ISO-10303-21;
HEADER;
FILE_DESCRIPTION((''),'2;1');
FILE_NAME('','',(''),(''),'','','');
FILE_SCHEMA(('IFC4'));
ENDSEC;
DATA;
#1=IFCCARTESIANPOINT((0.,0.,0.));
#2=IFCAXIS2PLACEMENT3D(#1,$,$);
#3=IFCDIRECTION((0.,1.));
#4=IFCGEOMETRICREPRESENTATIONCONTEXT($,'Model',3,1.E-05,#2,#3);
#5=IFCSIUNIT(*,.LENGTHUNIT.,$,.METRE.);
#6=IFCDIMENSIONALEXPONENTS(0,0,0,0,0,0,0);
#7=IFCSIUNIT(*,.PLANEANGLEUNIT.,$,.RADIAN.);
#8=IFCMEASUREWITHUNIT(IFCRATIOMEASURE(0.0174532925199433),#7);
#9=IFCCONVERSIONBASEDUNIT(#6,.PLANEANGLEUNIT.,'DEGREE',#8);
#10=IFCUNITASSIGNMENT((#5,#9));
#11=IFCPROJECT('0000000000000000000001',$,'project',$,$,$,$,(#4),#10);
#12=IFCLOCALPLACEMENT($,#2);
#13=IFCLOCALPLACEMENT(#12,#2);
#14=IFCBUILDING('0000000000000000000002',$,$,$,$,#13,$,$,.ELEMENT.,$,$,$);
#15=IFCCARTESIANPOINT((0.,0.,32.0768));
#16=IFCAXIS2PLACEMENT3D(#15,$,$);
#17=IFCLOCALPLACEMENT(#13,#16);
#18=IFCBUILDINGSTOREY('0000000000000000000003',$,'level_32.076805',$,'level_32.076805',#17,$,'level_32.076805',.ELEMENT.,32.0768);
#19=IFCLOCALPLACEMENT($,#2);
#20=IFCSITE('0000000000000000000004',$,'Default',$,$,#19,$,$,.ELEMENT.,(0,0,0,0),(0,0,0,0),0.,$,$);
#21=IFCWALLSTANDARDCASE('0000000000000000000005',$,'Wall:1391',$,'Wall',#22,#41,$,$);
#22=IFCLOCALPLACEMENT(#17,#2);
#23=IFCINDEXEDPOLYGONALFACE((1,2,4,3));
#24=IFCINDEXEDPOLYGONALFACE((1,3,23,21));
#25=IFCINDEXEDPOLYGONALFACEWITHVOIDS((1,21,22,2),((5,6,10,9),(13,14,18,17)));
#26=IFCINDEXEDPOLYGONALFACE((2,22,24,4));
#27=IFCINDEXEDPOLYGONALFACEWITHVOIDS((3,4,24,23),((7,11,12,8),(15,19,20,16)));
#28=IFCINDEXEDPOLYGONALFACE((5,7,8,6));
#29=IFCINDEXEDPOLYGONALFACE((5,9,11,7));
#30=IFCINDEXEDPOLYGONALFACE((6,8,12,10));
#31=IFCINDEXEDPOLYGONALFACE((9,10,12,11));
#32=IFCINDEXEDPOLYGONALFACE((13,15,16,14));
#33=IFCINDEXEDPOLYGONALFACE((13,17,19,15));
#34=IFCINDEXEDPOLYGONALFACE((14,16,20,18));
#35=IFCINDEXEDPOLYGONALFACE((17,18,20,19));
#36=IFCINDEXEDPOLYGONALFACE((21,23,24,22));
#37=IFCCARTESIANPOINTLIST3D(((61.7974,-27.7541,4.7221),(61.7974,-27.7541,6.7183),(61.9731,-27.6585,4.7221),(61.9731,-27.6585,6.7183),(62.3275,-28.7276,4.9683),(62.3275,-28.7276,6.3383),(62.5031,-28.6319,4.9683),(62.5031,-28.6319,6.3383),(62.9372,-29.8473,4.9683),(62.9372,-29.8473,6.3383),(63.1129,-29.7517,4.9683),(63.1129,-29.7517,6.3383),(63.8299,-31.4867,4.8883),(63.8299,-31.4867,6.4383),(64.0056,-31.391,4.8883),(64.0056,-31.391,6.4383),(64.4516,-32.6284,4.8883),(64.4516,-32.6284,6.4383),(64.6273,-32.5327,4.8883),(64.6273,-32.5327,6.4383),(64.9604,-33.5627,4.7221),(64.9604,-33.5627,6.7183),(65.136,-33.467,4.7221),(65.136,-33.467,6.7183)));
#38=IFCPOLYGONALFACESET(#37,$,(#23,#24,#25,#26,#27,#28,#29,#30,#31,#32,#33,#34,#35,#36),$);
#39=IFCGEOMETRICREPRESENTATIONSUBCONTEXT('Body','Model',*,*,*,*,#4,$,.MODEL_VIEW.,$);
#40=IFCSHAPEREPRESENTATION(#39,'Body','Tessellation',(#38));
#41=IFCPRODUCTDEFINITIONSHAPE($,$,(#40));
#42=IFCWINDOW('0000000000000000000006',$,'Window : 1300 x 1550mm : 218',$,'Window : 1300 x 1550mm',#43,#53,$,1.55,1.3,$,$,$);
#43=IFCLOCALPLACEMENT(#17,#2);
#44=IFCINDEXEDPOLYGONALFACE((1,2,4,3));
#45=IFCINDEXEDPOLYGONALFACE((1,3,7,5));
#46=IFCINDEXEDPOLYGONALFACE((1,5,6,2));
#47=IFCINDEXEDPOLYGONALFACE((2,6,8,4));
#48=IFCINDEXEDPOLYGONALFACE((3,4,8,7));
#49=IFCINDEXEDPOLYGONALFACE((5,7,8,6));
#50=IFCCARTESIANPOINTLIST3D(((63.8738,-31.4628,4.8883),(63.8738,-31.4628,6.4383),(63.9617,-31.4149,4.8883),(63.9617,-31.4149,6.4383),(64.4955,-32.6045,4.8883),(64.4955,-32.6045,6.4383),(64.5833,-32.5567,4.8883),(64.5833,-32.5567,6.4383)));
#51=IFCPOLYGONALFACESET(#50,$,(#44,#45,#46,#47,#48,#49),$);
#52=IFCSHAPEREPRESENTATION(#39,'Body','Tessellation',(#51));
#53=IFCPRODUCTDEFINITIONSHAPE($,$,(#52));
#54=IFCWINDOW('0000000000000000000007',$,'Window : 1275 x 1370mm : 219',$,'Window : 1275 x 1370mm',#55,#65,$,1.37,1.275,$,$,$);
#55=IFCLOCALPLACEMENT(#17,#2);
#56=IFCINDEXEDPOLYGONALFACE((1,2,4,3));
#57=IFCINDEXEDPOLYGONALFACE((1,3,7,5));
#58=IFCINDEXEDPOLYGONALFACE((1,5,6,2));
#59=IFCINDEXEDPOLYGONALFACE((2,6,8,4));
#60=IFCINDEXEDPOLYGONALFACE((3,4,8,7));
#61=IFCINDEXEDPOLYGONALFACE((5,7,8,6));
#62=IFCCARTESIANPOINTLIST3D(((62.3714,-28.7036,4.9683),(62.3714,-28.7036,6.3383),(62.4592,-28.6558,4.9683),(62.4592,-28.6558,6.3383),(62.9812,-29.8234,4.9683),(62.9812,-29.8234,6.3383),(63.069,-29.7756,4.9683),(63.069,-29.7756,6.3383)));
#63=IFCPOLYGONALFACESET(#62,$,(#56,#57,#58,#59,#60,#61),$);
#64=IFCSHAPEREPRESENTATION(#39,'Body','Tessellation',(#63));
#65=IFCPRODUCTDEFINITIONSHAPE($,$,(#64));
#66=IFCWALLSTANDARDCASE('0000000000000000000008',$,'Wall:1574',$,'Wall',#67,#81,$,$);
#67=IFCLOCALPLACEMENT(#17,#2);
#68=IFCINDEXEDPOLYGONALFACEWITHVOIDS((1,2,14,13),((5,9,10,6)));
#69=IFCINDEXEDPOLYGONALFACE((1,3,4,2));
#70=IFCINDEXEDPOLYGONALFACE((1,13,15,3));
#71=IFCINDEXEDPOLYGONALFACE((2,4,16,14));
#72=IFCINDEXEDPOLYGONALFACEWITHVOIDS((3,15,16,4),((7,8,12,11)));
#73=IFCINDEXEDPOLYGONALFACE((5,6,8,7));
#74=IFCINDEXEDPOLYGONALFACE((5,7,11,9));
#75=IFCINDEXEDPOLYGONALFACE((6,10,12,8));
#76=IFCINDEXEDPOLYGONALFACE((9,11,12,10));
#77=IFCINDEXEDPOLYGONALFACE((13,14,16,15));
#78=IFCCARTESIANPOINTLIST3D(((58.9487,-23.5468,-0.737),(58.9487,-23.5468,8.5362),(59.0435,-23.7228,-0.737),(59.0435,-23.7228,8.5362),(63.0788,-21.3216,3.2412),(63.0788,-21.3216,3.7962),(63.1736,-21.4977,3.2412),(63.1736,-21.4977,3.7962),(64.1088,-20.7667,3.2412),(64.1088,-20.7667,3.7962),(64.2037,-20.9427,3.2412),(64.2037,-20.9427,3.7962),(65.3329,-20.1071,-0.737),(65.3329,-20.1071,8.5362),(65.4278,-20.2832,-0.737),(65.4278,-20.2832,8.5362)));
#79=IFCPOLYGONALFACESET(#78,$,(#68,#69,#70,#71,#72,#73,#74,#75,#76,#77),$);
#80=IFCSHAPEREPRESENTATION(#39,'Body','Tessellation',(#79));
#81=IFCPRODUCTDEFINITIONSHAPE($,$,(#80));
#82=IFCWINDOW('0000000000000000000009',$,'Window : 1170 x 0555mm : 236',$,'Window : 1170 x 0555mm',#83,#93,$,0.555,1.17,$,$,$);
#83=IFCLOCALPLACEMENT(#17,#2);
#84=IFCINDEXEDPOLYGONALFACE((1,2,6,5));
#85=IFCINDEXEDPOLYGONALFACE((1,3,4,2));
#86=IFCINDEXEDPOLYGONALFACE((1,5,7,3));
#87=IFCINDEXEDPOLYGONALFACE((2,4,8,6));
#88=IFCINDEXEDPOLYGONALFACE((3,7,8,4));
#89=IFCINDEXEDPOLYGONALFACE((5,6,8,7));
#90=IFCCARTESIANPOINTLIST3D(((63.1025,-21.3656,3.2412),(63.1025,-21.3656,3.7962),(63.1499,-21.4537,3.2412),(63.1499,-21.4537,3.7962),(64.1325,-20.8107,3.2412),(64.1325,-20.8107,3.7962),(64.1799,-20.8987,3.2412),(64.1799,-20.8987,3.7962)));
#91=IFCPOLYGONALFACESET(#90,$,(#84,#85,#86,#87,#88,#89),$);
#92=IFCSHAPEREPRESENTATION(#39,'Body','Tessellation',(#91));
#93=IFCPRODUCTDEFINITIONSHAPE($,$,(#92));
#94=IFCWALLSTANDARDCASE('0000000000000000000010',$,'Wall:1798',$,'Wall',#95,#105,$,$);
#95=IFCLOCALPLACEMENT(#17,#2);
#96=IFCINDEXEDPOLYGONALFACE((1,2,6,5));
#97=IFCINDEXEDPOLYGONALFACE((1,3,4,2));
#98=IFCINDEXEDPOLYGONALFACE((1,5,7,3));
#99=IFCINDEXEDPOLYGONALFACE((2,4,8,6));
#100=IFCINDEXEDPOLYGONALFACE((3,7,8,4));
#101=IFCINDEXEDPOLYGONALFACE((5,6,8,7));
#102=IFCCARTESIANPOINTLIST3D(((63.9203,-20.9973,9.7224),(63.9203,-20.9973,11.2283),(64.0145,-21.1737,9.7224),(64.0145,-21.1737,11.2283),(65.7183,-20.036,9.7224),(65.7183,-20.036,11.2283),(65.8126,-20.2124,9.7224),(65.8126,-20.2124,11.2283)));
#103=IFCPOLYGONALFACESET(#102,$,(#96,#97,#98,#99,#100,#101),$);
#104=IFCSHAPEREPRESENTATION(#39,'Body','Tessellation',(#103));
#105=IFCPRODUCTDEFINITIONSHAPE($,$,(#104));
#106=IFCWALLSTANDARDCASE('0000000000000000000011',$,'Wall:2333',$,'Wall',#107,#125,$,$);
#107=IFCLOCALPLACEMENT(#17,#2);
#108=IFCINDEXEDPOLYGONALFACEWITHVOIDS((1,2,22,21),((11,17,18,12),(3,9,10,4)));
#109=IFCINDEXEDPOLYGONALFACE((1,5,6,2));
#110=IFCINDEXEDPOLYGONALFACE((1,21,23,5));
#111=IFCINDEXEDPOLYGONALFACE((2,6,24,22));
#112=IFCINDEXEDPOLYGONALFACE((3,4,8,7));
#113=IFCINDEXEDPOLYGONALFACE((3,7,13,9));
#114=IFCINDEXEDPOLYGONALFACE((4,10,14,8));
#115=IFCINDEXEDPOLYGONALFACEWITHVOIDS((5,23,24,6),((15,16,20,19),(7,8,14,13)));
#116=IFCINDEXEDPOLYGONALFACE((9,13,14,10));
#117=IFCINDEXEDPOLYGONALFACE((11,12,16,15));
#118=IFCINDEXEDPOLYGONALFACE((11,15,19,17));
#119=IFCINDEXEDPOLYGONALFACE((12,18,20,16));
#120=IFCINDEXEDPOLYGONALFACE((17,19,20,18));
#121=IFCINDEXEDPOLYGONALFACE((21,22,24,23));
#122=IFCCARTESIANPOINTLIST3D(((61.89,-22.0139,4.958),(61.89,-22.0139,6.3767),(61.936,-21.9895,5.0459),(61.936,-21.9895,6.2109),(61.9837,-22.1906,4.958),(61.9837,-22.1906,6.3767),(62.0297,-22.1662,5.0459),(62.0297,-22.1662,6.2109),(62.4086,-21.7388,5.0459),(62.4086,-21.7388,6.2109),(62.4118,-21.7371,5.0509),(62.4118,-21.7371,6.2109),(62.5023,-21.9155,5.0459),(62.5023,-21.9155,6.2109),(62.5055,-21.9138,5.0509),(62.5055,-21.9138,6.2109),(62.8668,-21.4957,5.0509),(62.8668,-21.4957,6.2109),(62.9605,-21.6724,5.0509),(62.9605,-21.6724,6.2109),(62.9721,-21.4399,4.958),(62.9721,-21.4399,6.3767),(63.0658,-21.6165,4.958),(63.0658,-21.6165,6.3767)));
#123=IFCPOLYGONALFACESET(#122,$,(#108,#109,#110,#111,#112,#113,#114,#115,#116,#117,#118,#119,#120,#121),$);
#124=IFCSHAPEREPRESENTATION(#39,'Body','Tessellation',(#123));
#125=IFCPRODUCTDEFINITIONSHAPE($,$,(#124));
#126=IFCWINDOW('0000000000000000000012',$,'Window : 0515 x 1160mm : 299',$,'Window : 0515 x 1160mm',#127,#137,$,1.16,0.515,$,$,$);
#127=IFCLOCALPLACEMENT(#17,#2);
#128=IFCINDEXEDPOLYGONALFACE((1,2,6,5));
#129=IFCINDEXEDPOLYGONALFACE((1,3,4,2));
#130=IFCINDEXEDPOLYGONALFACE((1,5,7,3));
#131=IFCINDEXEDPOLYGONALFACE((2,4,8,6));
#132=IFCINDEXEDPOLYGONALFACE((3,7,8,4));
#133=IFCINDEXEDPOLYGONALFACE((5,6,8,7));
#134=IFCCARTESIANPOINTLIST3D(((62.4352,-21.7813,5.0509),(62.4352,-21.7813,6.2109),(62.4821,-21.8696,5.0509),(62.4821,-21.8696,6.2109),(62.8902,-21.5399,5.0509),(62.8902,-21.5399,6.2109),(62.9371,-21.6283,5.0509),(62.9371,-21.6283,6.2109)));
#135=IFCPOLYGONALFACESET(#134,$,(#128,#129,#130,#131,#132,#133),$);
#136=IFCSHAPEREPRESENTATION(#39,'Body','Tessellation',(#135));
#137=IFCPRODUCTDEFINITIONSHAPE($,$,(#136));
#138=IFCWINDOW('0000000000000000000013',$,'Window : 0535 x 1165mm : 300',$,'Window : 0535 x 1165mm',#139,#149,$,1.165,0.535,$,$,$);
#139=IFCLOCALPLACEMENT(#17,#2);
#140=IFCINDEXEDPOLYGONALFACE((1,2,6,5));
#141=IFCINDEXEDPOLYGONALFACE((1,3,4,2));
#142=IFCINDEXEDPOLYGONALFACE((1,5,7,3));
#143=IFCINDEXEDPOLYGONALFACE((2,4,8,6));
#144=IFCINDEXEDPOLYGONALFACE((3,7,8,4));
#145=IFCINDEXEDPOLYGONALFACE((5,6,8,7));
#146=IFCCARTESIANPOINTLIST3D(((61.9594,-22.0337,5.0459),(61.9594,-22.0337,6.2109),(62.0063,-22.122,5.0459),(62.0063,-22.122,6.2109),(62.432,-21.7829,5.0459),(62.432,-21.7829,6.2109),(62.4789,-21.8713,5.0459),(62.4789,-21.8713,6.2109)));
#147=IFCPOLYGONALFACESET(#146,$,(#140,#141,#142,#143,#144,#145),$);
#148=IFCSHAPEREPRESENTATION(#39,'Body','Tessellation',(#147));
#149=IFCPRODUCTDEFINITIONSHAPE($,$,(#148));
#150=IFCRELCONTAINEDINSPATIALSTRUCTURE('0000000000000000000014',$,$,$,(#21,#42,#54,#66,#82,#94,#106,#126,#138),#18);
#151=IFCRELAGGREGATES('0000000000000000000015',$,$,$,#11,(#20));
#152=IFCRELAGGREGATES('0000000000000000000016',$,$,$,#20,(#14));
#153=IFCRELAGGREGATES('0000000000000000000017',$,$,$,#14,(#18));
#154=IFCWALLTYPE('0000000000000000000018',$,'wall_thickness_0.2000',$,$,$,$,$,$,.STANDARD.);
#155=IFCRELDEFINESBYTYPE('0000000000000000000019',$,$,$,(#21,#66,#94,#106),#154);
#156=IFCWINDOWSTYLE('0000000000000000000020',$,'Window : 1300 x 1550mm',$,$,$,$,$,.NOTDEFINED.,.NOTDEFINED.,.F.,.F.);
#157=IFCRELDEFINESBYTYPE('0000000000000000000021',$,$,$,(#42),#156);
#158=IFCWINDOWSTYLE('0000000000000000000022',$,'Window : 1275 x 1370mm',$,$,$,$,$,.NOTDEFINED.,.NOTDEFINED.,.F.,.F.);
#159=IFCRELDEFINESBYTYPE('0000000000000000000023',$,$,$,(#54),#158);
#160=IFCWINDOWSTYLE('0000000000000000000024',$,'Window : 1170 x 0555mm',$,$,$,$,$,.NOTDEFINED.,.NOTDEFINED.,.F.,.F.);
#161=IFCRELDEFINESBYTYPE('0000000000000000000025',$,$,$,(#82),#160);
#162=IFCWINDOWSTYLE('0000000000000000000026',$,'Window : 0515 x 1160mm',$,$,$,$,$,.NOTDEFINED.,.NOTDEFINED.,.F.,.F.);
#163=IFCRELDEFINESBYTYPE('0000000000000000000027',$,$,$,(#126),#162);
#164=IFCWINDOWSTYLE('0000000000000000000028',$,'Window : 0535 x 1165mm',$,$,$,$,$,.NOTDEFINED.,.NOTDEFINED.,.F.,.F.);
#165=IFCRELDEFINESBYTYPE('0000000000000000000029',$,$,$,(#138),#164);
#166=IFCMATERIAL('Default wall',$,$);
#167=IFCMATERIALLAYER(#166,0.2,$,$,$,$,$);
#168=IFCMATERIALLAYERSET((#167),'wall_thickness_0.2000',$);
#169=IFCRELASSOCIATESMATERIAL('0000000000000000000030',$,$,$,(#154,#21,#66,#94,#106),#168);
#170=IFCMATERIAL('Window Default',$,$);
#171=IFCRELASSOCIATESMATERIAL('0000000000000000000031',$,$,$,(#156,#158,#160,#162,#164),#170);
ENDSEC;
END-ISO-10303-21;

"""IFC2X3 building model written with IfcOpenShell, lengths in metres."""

from ifc_helpers import new_model, entity, si_unit, converted_unit, direction, frame, frame_2d, origin, origin_2d_with_axis, place, context, subcontext, project, spatial, polyline, rectangle, outline, extrude, source, transform, mapped, material, layer, layer_set, layer_usage, type_object, type_shapes, element, fill, save


model = new_model("IFC2X3")

# Units and contexts
model_context = context("Model", 3, precision=1e-05, world=origin(), true_north=direction((0.0, 1.0)))
body_context = subcontext(model_context, "Body", "Model", "MODEL_VIEW")
ifc_project = project(units=[si_unit("LENGTHUNIT", "METRE"), converted_unit("PLANEANGLEUNIT", "DEGREE", entity("IfcRatioMeasure", 0.0174532925199433), si_unit("PLANEANGLEUNIT", "RADIAN"), dimensions=[0, 0, 0, 0, 0, 0, 0])], contexts=[model_context])

# Site, building, storey
site_placement = place(None, origin())
site = spatial("IfcSite", under=ifc_project, at=site_placement, Name="Default", CompositionType="ELEMENT", RefLatitude=(0, 0, 0, 0), RefLongitude=(0, 0, 0, 0), RefElevation=0.0)
placement_1 = place(None, origin())
building_placement = place(placement_1, origin())
building = spatial("IfcBuilding", under=site, at=building_placement, CompositionType="ELEMENT")
storey_placement = place(building_placement, frame((0.0, 0.0, 32.0768)))
storey = spatial("IfcBuildingStorey", under=building, at=storey_placement, Name="level_32.076805", ObjectType="level_32.076805", LongName="level_32.076805", CompositionType="ELEMENT", Elevation=32.0768)

# Shared definitions
ifc_material_1 = material(Name="Default wall")
ifc_layer = layer(ifc_material_1, 0.2)
ifc_layer_set = layer_set([ifc_layer], Name="wall_thickness_0.2000")
ifc_layer_usage = layer_usage(ifc_layer_set, "AXIS2", "POSITIVE", -0.1)
wall_type = type_object("IfcWallType", Name="wall_thickness_0.2000", PredefinedType="STANDARD", material=ifc_layer_set)

# Shared definitions
ifc_material_2 = material(Name="Window Default")

# Wall, openings, windows
placement_2 = place(building_placement, frame((0.0, 0.0, 36.7989)))
wall_1_placement = place(placement_2, frame((61.8853, -27.7063, 0.0), z_axis=(0.0, 0.0, 1.0), x_axis=(0.478225, -0.878237, 0.0)))
wall_1 = element("IfcWallStandardCase", 1, at=wall_1_placement, inside=storey, type_object=wall_type, material=ifc_layer_usage, Name="Wall:1391", ObjectType="Wall", context=body_context, shape_type="SweptSolid", body=[
    extrude(outline(polyline([(6.6139, -0.1), (6.6139, 0.1), (0.0, 0.1), (0.0, -0.1), (6.6139, -0.1)])), origin(), (0.0, 0.0, 1.0), 1.9962),
])
opening_1_placement = place(wall_1_placement, frame((4.2501, -0.1, 0.1662)))
opening_1 = element("IfcOpeningElement", 2, at=opening_1_placement, cuts=wall_1, ObjectType="Opening", context=body_context, shape_type="SweptSolid", body=[
    extrude(rectangle(XDim=1.3, YDim=1.55, at=frame_2d((0.775, 0.65), x_axis=(0.0, 1.0))), frame((0.0, 0.0, 0.0), z_axis=(0.0, 1.0, 0.0), x_axis=(0.0, 0.0, 1.0)), (0.0, 0.0, 1.0), 0.2),
])
opening_2_placement = place(wall_1_placement, frame((1.1084, -0.1, 0.2462)))
opening_2 = element("IfcOpeningElement", 3, at=opening_2_placement, cuts=wall_1, ObjectType="Opening", context=body_context, shape_type="SweptSolid", body=[
    extrude(rectangle(XDim=1.275, YDim=1.37, at=frame_2d((0.685, 0.6375), x_axis=(0.0, 1.0))), frame((0.0, 0.0, 0.0), z_axis=(0.0, 1.0, 0.0), x_axis=(0.0, 0.0, 1.0)), (0.0, 0.0, 1.0), 0.2),
])
window_style_1 = type_object("IfcWindowStyle", Name="Window : 1300 x 1550mm", ConstructionType="NOTDEFINED", OperationType="NOTDEFINED", ParameterTakesPrecedence=False, Sizeable=False, material=ifc_material_2)
shared_shape_1 = source(origin(), body_context, "Body", "SweptSolid", [
    extrude(rectangle(XDim=0.1, YDim=1.3, at=origin_2d_with_axis()), frame((0.65, 0.1, 0.0), z_axis=(0.0, 0.0, 1.0), x_axis=(0.0, 1.0, 0.0)), (0.0, 0.0, 1.0), 1.55),
])
type_shapes(window_style_1, [shared_shape_1])
window_1_placement = place(opening_1_placement, origin())
window_1 = element("IfcWindow", 4, at=window_1_placement, inside=storey, type_object=window_style_1, Name="Window : 1300 x 1550mm : 218", ObjectType="Window : 1300 x 1550mm", OverallHeight=1.55, OverallWidth=1.3, context=body_context, shape_type="MappedRepresentation", body=[
    mapped(shared_shape_1, transform((0.0, 0.0, 0.0), scale=1.0)),
])
fill(opening_1, window_1)
window_style_2 = type_object("IfcWindowStyle", Name="Window : 1275 x 1370mm", ConstructionType="NOTDEFINED", OperationType="NOTDEFINED", ParameterTakesPrecedence=False, Sizeable=False, material=ifc_material_2)
shared_shape_2 = source(origin(), body_context, "Body", "SweptSolid", [
    extrude(rectangle(XDim=0.1, YDim=1.275, at=origin_2d_with_axis()), frame((0.6375, 0.1, 0.0), z_axis=(0.0, 0.0, 1.0), x_axis=(0.0, 1.0, 0.0)), (0.0, 0.0, 1.0), 1.37),
])
type_shapes(window_style_2, [shared_shape_2])
window_2_placement = place(opening_2_placement, origin())
window_2 = element("IfcWindow", 5, at=window_2_placement, inside=storey, type_object=window_style_2, Name="Window : 1275 x 1370mm : 219", ObjectType="Window : 1275 x 1370mm", OverallHeight=1.37, OverallWidth=1.275, context=body_context, shape_type="MappedRepresentation", body=[
    mapped(shared_shape_2, transform((0.0, 0.0, 0.0), scale=1.0)),
])
fill(opening_2, window_2)

# Wall, opening, window
placement_3 = place(building_placement, frame((0.0, 0.0, 31.3398)))
wall_2_placement = place(placement_3, frame((65.3804, -20.1952, 0.0), z_axis=(0.0, 0.0, 1.0), x_axis=(-0.88036, -0.474307, 0.0)))
wall_2 = element("IfcWallStandardCase", 6, at=wall_2_placement, inside=storey, type_object=wall_type, material=ifc_layer_usage, Name="Wall:1574", ObjectType="Wall", context=body_context, shape_type="SweptSolid", body=[
    extrude(outline(polyline([(7.2519, -0.1), (7.2519, 0.1), (0.0, 0.1), (0.0, -0.1), (7.2519, -0.1)])), origin(), (0.0, 0.0, 1.0), 9.2732),
])
opening_3_placement = place(wall_2_placement, frame((1.3905, -0.1, 3.9782)))
opening_3 = element("IfcOpeningElement", 7, at=opening_3_placement, cuts=wall_2, ObjectType="Opening", context=body_context, shape_type="SweptSolid", body=[
    extrude(rectangle(XDim=1.17, YDim=0.555, at=frame_2d((0.2775, 0.585), x_axis=(0.0, 1.0))), frame((0.0, 0.0, 0.0), z_axis=(0.0, 1.0, 0.0), x_axis=(0.0, 0.0, 1.0)), (0.0, 0.0, 1.0), 0.2),
])
window_style_3 = type_object("IfcWindowStyle", Name="Window : 1170 x 0555mm", ConstructionType="NOTDEFINED", OperationType="NOTDEFINED", ParameterTakesPrecedence=False, Sizeable=False, material=ifc_material_2)
shared_shape_3 = source(origin(), body_context, "Body", "SweptSolid", [
    extrude(rectangle(XDim=0.1, YDim=1.17, at=origin_2d_with_axis()), frame((0.585, 0.1, 0.0), z_axis=(0.0, 0.0, 1.0), x_axis=(0.0, 1.0, 0.0)), (0.0, 0.0, 1.0), 0.555),
])
type_shapes(window_style_3, [shared_shape_3])
window_3_placement = place(opening_3_placement, origin())
window_3 = element("IfcWindow", 8, at=window_3_placement, inside=storey, type_object=window_style_3, Name="Window : 1170 x 0555mm : 236", ObjectType="Window : 1170 x 0555mm", OverallHeight=0.555, OverallWidth=1.17, context=body_context, shape_type="MappedRepresentation", body=[
    mapped(shared_shape_3, transform((0.0, 0.0, 0.0), scale=1.0)),
])
fill(opening_3, window_3)

# Wall
placement_4 = place(building_placement, frame((0.0, 0.0, 41.7992)))
wall_3_placement = place(placement_4, frame((63.9674, -21.0855, 0.0), z_axis=(0.0, 0.0, 1.0), x_axis=(0.881883, 0.471469, 0.0)))
element("IfcWallStandardCase", 9, at=wall_3_placement, inside=storey, type_object=wall_type, material=ifc_layer_usage, Name="Wall:1798", ObjectType="Wall", context=body_context, shape_type="SweptSolid", body=[
    extrude(outline(polyline([(2.0389, -0.1), (2.0389, 0.1), (0.0, 0.1), (0.0, -0.1), (2.0389, -0.1)])), origin(), (0.0, 0.0, 1.0), 1.5059),
])

# Wall, openings, windows
placement_5 = place(building_placement, frame((0.0, 0.0, 37.0348)))
wall_4_placement = place(placement_5, frame((63.019, -21.5282, 0.0), z_axis=(0.0, 0.0, 1.0), x_axis=(-0.883403, -0.468613, 0.0)))
wall_4 = element("IfcWallStandardCase", 10, at=wall_4_placement, inside=storey, type_object=wall_type, material=ifc_layer_usage, Name="Wall:2333", ObjectType="Wall", context=body_context, shape_type="SweptSolid", body=[
    extrude(outline(polyline([(1.225, -0.1), (1.225, 0.1), (0.0, 0.1), (0.0, -0.1), (1.225, -0.1)])), origin(), (0.0, 0.0, 1.0), 1.4187),
])
opening_4_placement = place(wall_4_placement, frame((0.1193, -0.1, 0.0929)))
opening_4 = element("IfcOpeningElement", 11, at=opening_4_placement, cuts=wall_4, ObjectType="Opening", context=body_context, shape_type="SweptSolid", body=[
    extrude(rectangle(XDim=0.515, YDim=1.16, at=frame_2d((0.58, 0.2575), x_axis=(0.0, 1.0))), frame((0.0, 0.0, 0.0), z_axis=(0.0, 1.0, 0.0), x_axis=(0.0, 0.0, 1.0)), (0.0, 0.0, 1.0), 0.2),
])
opening_5_placement = place(wall_4_placement, frame((0.6379, -0.1, 0.0879)))
opening_5 = element("IfcOpeningElement", 12, at=opening_5_placement, cuts=wall_4, ObjectType="Opening", context=body_context, shape_type="SweptSolid", body=[
    extrude(rectangle(XDim=0.535, YDim=1.165, at=frame_2d((0.5825, 0.2675), x_axis=(0.0, 1.0))), frame((0.0, 0.0, 0.0), z_axis=(0.0, 1.0, 0.0), x_axis=(0.0, 0.0, 1.0)), (0.0, 0.0, 1.0), 0.2),
])
window_style_4 = type_object("IfcWindowStyle", Name="Window : 0515 x 1160mm", ConstructionType="NOTDEFINED", OperationType="NOTDEFINED", ParameterTakesPrecedence=False, Sizeable=False, material=ifc_material_2)
shared_shape_4 = source(origin(), body_context, "Body", "SweptSolid", [
    extrude(rectangle(XDim=0.1, YDim=0.515, at=origin_2d_with_axis()), frame((0.2575, 0.1, 0.0), z_axis=(0.0, 0.0, 1.0), x_axis=(0.0, 1.0, 0.0)), (0.0, 0.0, 1.0), 1.16),
])
type_shapes(window_style_4, [shared_shape_4])
window_4_placement = place(opening_4_placement, origin())
window_4 = element("IfcWindow", 13, at=window_4_placement, inside=storey, type_object=window_style_4, Name="Window : 0515 x 1160mm : 299", ObjectType="Window : 0515 x 1160mm", OverallHeight=1.16, OverallWidth=0.515, context=body_context, shape_type="MappedRepresentation", body=[
    mapped(shared_shape_4, transform((0.0, 0.0, 0.0), scale=1.0)),
])
fill(opening_4, window_4)
window_style_5 = type_object("IfcWindowStyle", Name="Window : 0535 x 1165mm", ConstructionType="NOTDEFINED", OperationType="NOTDEFINED", ParameterTakesPrecedence=False, Sizeable=False, material=ifc_material_2)
shared_shape_5 = source(origin(), body_context, "Body", "SweptSolid", [
    extrude(rectangle(XDim=0.1, YDim=0.535, at=origin_2d_with_axis()), frame((0.2675, 0.1, 0.0), z_axis=(0.0, 0.0, 1.0), x_axis=(0.0, 1.0, 0.0)), (0.0, 0.0, 1.0), 1.165),
])
type_shapes(window_style_5, [shared_shape_5])
window_5_placement = place(opening_5_placement, origin())
window_5 = element("IfcWindow", 14, at=window_5_placement, inside=storey, type_object=window_style_5, Name="Window : 0535 x 1165mm : 300", ObjectType="Window : 0535 x 1165mm", OverallHeight=1.165, OverallWidth=0.535, context=body_context, shape_type="MappedRepresentation", body=[
    mapped(shared_shape_5, transform((0.0, 0.0, 0.0), scale=1.0)),
])
fill(opening_5, window_5)

save(model, "model.ifc")
